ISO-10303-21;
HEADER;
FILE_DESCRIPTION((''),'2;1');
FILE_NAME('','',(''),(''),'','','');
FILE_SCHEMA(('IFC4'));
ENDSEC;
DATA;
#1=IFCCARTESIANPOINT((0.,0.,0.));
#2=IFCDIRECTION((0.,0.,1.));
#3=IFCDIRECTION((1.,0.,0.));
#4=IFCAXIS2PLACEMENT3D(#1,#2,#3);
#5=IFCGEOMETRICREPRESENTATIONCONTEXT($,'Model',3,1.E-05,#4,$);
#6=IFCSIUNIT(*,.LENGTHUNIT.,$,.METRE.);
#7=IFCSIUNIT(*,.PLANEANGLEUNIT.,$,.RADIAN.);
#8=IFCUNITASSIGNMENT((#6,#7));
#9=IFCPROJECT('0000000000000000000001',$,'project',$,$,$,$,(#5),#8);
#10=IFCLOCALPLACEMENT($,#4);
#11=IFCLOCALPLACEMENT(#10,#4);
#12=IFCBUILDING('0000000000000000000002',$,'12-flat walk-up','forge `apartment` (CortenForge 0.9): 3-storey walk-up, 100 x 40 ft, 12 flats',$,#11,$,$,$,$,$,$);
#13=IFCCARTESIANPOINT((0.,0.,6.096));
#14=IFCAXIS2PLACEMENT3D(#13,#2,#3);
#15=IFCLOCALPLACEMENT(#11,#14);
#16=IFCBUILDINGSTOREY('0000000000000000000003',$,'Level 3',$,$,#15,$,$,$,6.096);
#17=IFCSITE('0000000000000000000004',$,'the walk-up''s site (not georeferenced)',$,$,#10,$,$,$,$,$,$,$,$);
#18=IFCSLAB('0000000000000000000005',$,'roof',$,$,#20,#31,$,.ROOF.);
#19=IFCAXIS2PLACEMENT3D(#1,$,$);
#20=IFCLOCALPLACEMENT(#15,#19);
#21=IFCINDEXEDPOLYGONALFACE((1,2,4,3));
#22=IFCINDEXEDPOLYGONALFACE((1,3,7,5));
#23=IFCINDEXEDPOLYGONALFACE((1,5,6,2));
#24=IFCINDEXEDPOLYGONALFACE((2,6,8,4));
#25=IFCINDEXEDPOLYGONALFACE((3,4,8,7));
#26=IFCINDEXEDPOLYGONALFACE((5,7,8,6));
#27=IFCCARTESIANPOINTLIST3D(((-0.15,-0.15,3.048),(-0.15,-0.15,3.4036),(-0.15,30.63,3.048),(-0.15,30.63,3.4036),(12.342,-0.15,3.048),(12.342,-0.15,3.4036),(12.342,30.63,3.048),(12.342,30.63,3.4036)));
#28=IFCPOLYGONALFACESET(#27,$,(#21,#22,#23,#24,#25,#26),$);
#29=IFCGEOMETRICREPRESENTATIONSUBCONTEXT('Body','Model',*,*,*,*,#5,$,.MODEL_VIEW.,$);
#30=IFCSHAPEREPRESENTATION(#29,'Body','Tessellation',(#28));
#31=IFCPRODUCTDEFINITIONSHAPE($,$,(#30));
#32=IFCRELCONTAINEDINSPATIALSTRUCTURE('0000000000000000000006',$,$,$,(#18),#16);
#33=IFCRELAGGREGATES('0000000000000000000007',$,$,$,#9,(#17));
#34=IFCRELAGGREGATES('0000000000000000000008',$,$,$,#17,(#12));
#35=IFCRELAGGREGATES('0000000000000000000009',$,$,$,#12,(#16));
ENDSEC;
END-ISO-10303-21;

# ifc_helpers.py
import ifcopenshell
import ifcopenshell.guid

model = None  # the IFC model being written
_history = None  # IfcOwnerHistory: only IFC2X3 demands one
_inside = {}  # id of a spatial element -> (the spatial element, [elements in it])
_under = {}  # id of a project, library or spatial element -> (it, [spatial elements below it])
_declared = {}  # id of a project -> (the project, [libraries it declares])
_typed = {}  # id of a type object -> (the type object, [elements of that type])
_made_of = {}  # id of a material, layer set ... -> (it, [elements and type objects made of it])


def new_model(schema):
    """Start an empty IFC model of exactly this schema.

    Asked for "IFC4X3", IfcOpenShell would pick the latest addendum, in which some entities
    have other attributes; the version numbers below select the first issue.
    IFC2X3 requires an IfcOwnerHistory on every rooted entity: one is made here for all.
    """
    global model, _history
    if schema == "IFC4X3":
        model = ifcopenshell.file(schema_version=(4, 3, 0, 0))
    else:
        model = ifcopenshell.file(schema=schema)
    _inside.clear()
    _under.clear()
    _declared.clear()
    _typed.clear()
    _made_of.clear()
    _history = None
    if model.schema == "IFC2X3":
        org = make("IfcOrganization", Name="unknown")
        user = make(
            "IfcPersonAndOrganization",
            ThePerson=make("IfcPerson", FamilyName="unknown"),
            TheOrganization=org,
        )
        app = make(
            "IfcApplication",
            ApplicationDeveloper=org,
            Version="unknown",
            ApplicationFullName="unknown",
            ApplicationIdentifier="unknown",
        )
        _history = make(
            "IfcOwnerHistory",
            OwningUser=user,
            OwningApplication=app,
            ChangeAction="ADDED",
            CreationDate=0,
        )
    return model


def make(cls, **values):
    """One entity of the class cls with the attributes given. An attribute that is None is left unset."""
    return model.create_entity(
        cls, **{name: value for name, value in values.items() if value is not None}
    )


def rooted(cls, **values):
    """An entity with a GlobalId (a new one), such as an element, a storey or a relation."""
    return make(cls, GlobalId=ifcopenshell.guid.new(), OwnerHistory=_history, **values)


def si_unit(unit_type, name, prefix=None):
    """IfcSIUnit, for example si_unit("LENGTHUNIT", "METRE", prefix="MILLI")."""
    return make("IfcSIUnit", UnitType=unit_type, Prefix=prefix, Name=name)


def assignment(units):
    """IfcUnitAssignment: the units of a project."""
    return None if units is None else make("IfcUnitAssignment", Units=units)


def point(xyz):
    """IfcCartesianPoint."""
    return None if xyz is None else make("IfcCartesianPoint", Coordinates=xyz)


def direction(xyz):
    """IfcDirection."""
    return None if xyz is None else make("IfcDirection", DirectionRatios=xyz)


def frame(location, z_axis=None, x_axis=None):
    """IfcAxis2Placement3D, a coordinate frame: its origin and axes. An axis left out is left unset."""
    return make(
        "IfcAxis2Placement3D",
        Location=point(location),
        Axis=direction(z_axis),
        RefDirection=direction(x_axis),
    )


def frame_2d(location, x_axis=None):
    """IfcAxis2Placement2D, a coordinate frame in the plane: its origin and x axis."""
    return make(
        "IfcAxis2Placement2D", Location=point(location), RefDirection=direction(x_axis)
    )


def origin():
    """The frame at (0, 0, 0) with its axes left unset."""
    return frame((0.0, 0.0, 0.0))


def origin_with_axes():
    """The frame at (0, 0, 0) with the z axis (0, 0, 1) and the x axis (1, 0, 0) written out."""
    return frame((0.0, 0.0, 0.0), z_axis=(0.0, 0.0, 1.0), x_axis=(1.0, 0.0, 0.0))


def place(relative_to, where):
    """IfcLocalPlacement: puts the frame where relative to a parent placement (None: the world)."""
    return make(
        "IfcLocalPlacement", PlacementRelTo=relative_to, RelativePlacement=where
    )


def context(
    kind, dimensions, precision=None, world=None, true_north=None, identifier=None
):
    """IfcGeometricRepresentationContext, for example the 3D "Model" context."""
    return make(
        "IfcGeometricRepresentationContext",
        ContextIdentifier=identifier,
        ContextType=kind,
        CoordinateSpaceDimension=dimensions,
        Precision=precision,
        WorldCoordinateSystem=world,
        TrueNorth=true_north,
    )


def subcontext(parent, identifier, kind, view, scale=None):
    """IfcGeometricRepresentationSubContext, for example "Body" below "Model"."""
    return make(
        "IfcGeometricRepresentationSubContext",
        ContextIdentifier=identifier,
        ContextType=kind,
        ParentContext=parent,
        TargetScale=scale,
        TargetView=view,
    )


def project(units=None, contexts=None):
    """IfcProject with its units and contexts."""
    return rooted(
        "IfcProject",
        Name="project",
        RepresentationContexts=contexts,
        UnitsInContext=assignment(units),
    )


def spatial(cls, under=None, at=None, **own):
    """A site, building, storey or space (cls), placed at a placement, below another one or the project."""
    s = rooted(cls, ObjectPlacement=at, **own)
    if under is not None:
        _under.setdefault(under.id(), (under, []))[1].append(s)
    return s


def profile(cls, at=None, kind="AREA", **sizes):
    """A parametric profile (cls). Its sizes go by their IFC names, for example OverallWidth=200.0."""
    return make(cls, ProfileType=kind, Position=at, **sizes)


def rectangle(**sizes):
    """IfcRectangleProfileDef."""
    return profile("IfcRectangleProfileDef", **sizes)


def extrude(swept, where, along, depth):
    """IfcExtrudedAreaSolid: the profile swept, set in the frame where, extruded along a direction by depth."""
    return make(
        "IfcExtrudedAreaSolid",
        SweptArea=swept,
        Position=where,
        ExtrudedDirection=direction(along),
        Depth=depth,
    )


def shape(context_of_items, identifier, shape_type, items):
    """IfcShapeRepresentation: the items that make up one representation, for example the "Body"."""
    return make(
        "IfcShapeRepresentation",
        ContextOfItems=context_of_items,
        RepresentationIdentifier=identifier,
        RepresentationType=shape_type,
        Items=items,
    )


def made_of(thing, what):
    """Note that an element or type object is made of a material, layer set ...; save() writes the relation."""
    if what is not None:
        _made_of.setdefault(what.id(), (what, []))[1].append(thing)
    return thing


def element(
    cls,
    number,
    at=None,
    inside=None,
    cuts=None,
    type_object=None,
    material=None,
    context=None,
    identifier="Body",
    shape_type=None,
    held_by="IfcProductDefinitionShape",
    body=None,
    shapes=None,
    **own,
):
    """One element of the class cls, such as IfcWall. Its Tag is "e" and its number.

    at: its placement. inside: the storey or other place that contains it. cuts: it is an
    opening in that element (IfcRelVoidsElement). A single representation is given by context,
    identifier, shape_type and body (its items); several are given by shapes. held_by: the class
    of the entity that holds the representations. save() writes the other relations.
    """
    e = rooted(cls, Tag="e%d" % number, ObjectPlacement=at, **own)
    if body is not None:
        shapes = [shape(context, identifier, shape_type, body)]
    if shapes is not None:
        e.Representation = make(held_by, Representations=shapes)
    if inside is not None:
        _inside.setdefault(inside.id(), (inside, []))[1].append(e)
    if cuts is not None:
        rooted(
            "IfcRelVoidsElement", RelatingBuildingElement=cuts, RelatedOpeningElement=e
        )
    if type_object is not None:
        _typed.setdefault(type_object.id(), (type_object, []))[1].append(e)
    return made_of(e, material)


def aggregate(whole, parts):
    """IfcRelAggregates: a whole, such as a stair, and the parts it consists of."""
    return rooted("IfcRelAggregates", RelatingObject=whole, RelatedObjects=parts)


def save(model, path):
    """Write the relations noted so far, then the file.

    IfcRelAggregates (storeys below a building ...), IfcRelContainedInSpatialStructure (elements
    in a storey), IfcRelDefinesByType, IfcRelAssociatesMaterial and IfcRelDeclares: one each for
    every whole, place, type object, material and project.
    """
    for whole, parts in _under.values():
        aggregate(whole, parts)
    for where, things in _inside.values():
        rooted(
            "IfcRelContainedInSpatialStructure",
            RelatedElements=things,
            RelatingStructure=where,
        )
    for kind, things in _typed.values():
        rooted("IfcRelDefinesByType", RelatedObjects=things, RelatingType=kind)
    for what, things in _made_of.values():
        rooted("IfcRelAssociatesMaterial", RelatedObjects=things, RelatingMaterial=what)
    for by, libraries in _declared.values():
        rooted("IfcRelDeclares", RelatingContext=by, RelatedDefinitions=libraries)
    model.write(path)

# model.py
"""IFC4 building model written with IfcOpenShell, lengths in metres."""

from ifc_helpers import new_model, si_unit, frame, frame_2d, origin, origin_with_axes, place, context, subcontext, project, spatial, rectangle, extrude, element, save


model = new_model("IFC4")

# Units and contexts
model_context = context("Model", 3, precision=1e-05, world=origin_with_axes())
body_context = subcontext(model_context, "Body", "Model", "MODEL_VIEW")
ifc_project = project(units=[si_unit("LENGTHUNIT", "METRE"), si_unit("PLANEANGLEUNIT", "RADIAN")], contexts=[model_context])

# Site, building, storey
site_placement = place(None, origin_with_axes())
site = spatial("IfcSite", under=ifc_project, at=site_placement, Name="the walk-up's site (not georeferenced)")
building_placement = place(site_placement, origin_with_axes())
building = spatial("IfcBuilding", under=site, at=building_placement, Name="12-flat walk-up", Description="forge `apartment` (CortenForge 0.9): 3-storey walk-up, 100 x 40 ft, 12 flats")
storey_placement = place(building_placement, frame((0.0, 0.0, 6.096), z_axis=(0.0, 0.0, 1.0), x_axis=(1.0, 0.0, 0.0)))
storey = spatial("IfcBuildingStorey", under=building, at=storey_placement, Name="Level 3", Elevation=6.096)

# Slab
slab_placement = place(storey_placement, frame((-0.15, -0.15, 3.048), z_axis=(0.0, 0.0, 1.0), x_axis=(1.0, 0.0, 0.0)))
element("IfcSlab", 1, at=slab_placement, inside=storey, Name="roof", PredefinedType="ROOF", context=body_context, shape_type="SweptSolid", body=[
    extrude(rectangle(XDim=12.492, YDim=30.78, at=frame_2d((6.246, 15.39))), origin(), (0.0, 0.0, 1.0), 0.3556),
])

save(model, "model.ifc")
